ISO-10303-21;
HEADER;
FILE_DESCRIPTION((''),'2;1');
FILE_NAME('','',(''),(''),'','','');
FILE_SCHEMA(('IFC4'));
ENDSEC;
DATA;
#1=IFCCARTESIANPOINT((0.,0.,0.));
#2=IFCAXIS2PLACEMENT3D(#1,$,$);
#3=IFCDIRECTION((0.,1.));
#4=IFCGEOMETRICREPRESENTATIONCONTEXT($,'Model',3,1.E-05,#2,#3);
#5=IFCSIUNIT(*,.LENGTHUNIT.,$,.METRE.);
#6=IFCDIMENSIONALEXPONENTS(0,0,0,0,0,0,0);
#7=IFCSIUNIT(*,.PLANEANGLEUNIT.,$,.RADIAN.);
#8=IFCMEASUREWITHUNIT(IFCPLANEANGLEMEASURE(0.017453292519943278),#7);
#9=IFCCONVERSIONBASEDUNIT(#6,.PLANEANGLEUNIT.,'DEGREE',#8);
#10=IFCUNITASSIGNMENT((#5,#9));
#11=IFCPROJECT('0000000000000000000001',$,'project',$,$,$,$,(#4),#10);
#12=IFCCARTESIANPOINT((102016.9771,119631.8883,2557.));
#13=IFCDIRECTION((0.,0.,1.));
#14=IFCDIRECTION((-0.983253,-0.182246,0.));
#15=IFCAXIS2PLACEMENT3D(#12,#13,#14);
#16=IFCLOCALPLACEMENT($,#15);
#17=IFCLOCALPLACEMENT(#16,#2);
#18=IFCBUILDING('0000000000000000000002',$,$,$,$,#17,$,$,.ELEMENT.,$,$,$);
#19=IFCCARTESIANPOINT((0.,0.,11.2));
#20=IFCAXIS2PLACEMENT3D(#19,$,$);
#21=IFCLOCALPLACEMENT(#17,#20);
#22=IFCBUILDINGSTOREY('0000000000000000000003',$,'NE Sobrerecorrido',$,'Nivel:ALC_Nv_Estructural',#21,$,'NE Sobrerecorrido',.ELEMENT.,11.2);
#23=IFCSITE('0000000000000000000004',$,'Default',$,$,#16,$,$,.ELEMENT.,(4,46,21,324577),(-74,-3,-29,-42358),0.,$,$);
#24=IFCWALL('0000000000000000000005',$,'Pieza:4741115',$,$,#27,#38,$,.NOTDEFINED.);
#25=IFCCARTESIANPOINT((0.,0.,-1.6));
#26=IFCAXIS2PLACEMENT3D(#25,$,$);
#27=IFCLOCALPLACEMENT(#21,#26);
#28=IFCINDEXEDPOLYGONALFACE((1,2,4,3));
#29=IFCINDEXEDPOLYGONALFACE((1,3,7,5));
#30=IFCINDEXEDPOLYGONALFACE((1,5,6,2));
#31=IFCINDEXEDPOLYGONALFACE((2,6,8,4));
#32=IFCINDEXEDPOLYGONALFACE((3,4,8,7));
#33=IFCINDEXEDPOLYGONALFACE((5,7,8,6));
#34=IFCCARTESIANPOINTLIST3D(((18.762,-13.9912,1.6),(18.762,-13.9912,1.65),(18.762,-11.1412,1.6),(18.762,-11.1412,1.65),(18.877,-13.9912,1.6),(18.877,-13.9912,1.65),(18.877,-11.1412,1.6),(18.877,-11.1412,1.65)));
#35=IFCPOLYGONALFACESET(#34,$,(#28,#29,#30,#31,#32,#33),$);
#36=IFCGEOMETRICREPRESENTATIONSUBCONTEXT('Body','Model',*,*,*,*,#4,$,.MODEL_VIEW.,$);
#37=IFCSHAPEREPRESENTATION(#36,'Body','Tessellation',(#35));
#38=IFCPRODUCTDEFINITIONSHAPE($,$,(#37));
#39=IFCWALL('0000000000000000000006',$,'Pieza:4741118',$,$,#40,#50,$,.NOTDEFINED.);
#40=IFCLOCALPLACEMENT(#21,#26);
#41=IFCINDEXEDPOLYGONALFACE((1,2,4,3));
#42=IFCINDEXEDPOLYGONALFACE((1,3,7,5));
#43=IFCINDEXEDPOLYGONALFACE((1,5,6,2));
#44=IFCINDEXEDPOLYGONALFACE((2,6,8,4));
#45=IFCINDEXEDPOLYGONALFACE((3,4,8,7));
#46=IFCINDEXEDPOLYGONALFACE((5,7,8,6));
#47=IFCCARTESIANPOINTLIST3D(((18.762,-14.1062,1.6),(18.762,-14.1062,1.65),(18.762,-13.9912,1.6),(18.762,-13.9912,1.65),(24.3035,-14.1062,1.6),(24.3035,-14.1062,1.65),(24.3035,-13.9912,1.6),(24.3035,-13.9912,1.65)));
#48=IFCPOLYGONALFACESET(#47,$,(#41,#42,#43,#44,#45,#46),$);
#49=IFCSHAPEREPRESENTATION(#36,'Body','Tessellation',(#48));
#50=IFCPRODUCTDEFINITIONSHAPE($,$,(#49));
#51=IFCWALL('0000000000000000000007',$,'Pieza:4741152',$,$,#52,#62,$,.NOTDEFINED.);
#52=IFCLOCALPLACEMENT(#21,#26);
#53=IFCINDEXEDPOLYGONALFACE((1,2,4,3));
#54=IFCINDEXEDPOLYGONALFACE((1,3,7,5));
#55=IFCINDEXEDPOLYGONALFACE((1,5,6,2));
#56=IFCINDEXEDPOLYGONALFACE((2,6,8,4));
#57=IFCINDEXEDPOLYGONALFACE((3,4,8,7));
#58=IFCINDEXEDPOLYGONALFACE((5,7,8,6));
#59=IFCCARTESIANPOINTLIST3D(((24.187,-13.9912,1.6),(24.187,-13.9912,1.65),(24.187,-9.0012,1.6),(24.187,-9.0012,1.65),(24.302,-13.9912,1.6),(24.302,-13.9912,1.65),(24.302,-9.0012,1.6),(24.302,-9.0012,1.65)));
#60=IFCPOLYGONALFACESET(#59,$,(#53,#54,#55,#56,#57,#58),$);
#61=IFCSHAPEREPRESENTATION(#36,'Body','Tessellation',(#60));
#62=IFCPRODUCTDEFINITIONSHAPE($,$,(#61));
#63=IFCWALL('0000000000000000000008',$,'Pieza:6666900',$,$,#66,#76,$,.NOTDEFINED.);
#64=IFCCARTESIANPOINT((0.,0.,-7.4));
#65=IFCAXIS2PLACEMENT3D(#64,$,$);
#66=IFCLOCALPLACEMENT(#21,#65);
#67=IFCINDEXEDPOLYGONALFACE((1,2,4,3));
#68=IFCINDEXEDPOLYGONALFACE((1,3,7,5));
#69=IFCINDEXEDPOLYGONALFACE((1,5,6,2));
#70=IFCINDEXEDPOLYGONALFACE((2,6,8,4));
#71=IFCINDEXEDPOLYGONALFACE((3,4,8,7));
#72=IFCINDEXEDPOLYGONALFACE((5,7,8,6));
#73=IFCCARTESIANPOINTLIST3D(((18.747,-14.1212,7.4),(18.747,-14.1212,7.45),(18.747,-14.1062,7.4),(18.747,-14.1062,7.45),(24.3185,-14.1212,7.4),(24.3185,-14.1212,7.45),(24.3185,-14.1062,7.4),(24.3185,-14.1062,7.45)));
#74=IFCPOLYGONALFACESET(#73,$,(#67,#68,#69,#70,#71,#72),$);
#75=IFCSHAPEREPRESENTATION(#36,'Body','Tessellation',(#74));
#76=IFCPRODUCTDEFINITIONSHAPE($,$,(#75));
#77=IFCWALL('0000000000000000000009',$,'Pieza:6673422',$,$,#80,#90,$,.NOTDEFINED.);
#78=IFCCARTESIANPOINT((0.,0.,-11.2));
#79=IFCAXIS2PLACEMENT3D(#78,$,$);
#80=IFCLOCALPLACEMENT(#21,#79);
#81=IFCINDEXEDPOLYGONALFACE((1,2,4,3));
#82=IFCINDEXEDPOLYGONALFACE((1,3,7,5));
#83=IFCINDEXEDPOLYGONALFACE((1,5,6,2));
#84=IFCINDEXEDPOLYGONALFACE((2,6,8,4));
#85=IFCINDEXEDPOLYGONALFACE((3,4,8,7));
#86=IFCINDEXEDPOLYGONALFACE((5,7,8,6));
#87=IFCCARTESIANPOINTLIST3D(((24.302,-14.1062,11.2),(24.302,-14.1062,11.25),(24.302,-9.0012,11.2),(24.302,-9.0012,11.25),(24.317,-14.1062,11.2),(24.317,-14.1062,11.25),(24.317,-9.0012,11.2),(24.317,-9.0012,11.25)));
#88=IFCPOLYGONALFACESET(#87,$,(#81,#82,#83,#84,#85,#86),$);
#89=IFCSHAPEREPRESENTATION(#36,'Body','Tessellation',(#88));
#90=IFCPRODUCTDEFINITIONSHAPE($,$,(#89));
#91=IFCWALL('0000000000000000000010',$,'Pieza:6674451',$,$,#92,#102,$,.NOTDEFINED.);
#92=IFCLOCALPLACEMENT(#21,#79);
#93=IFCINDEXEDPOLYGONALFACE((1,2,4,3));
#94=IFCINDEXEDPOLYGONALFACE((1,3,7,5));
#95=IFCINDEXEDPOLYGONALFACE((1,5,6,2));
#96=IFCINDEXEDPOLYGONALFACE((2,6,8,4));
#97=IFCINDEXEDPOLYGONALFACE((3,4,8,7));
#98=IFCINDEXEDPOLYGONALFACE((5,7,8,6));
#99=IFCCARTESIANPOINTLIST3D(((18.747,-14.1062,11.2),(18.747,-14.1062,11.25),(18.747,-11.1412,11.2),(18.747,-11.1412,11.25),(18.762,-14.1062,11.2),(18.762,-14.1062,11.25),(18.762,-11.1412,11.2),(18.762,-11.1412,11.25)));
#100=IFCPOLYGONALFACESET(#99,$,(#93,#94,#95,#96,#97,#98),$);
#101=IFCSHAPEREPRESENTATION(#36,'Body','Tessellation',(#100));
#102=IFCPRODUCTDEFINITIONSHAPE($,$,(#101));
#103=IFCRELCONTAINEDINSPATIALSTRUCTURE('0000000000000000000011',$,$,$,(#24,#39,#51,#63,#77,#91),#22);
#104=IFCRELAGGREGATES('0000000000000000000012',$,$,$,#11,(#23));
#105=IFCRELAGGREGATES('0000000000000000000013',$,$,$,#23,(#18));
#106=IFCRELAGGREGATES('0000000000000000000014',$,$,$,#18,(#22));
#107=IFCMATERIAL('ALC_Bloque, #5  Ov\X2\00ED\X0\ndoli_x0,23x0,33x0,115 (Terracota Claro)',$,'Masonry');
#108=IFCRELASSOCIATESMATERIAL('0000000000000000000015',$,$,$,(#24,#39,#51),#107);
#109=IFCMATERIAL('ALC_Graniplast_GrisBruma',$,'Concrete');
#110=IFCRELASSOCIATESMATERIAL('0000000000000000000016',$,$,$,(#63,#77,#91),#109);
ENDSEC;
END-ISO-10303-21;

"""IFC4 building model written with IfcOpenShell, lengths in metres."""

from ifc_helpers import new_model, entity, si_unit, converted_unit, direction, frame, frame_2d, origin, place, context, subcontext, project, spatial, rectangle, extrude, material, element, save


model = new_model("IFC4")

# Units and contexts
model_context = context("Model", 3, precision=1e-05, world=origin(), true_north=direction((0.0, 1.0)))
body_context = subcontext(model_context, "Body", "Model", "MODEL_VIEW")
ifc_project = project(units=[si_unit("LENGTHUNIT", "METRE"), converted_unit("PLANEANGLEUNIT", "DEGREE", entity("IfcPlaneAngleMeasure", 0.017453292519943278), si_unit("PLANEANGLEUNIT", "RADIAN"), dimensions=[0, 0, 0, 0, 0, 0, 0])], contexts=[model_context])

# Site, building, storey
site_placement = place(None, frame((102016.9771, 119631.8883, 2557.0), z_axis=(0.0, 0.0, 1.0), x_axis=(-0.983253, -0.182246, 0.0)))
site = spatial("IfcSite", under=ifc_project, at=site_placement, Name="Default", CompositionType="ELEMENT", RefLatitude=(4, 46, 21, 324577), RefLongitude=(-74, -3, -29, -42358), RefElevation=0.0)
building_placement = place(site_placement, origin())
building = spatial("IfcBuilding", under=site, at=building_placement, CompositionType="ELEMENT")
storey_placement = place(building_placement, frame((0.0, 0.0, 11.2)))
storey = spatial("IfcBuildingStorey", under=building, at=storey_placement, Name="NE Sobrerecorrido", ObjectType="Nivel:ALC_Nv_Estructural", LongName="NE Sobrerecorrido", CompositionType="ELEMENT", Elevation=11.2)

# Walls
ifc_material_1 = material(Name="ALC_Bloque, #5  Ovíndoli_x0,23x0,33x0,115 (Terracota Claro)", Category="Masonry")
wall_1_placement = place(storey_placement, frame((0.0, 0.0, -1.6)))
element("IfcWall", 1, at=wall_1_placement, inside=storey, material=ifc_material_1, Name="Pieza:4741115", PredefinedType="NOTDEFINED", context=body_context, shape_type="SweptSolid", body=[
    extrude(rectangle(XDim=2.85, YDim=0.115, at=frame_2d((0.0, 0.0), x_axis=(1.0, 0.0))), frame((18.8195, -12.5662, 1.6), z_axis=(0.0, 0.0, 1.0), x_axis=(0.0, -1.0, 0.0)), (0.0, 0.0, 1.0), 0.05),
])
wall_2_placement = place(storey_placement, frame((0.0, 0.0, -1.6)))
element("IfcWall", 2, at=wall_2_placement, inside=storey, material=ifc_material_1, Name="Pieza:4741118", PredefinedType="NOTDEFINED", context=body_context, shape_type="SweptSolid", body=[
    extrude(rectangle(XDim=0.115, YDim=5.5415, at=frame_2d((0.0, 0.0), x_axis=(1.0, 0.0))), frame((21.5328, -14.0487, 1.6), z_axis=(0.0, 0.0, 1.0), x_axis=(0.0, -1.0, 0.0)), (0.0, 0.0, 1.0), 0.05),
])
wall_3_placement = place(storey_placement, frame((0.0, 0.0, -1.6)))
element("IfcWall", 3, at=wall_3_placement, inside=storey, material=ifc_material_1, Name="Pieza:4741152", PredefinedType="NOTDEFINED", context=body_context, shape_type="SweptSolid", body=[
    extrude(rectangle(XDim=4.99, YDim=0.115, at=frame_2d((0.0, 0.0), x_axis=(1.0, 0.0))), frame((24.2445, -11.4962, 1.6), z_axis=(0.0, 0.0, 1.0), x_axis=(0.0, -1.0, 0.0)), (0.0, 0.0, 1.0), 0.05),
])
ifc_material_2 = material(Name="ALC_Graniplast_GrisBruma", Category="Concrete")
wall_4_placement = place(storey_placement, frame((0.0, 0.0, -7.4)))
element("IfcWall", 4, at=wall_4_placement, inside=storey, material=ifc_material_2, Name="Pieza:6666900", PredefinedType="NOTDEFINED", context=body_context, shape_type="SweptSolid", body=[
    extrude(rectangle(XDim=0.015, YDim=5.5715, at=frame_2d((0.0, 0.0), x_axis=(1.0, 0.0))), frame((21.5328, -14.1137, 7.4), z_axis=(0.0, 0.0, 1.0), x_axis=(0.0, -1.0, 0.0)), (0.0, 0.0, 1.0), 0.05),
])
wall_5_placement = place(storey_placement, frame((0.0, 0.0, -11.2)))
element("IfcWall", 5, at=wall_5_placement, inside=storey, material=ifc_material_2, Name="Pieza:6673422", PredefinedType="NOTDEFINED", context=body_context, shape_type="SweptSolid", body=[
    extrude(rectangle(XDim=5.105, YDim=0.015, at=frame_2d((0.0, 0.0), x_axis=(1.0, 0.0))), frame((24.3095, -11.5537, 11.2), z_axis=(0.0, 0.0, 1.0), x_axis=(0.0, -1.0, 0.0)), (0.0, 0.0, 1.0), 0.05),
])
wall_6_placement = place(storey_placement, frame((0.0, 0.0, -11.2)))
element("IfcWall", 6, at=wall_6_placement, inside=storey, material=ifc_material_2, Name="Pieza:6674451", PredefinedType="NOTDEFINED", context=body_context, shape_type="SweptSolid", body=[
    extrude(rectangle(XDim=2.965, YDim=0.015, at=frame_2d((0.0, 0.0), x_axis=(1.0, 0.0))), frame((18.7545, -12.6237, 11.2), z_axis=(0.0, 0.0, 1.0), x_axis=(0.0, -1.0, 0.0)), (0.0, 0.0, 1.0), 0.05),
])

save(model, "model.ifc")
